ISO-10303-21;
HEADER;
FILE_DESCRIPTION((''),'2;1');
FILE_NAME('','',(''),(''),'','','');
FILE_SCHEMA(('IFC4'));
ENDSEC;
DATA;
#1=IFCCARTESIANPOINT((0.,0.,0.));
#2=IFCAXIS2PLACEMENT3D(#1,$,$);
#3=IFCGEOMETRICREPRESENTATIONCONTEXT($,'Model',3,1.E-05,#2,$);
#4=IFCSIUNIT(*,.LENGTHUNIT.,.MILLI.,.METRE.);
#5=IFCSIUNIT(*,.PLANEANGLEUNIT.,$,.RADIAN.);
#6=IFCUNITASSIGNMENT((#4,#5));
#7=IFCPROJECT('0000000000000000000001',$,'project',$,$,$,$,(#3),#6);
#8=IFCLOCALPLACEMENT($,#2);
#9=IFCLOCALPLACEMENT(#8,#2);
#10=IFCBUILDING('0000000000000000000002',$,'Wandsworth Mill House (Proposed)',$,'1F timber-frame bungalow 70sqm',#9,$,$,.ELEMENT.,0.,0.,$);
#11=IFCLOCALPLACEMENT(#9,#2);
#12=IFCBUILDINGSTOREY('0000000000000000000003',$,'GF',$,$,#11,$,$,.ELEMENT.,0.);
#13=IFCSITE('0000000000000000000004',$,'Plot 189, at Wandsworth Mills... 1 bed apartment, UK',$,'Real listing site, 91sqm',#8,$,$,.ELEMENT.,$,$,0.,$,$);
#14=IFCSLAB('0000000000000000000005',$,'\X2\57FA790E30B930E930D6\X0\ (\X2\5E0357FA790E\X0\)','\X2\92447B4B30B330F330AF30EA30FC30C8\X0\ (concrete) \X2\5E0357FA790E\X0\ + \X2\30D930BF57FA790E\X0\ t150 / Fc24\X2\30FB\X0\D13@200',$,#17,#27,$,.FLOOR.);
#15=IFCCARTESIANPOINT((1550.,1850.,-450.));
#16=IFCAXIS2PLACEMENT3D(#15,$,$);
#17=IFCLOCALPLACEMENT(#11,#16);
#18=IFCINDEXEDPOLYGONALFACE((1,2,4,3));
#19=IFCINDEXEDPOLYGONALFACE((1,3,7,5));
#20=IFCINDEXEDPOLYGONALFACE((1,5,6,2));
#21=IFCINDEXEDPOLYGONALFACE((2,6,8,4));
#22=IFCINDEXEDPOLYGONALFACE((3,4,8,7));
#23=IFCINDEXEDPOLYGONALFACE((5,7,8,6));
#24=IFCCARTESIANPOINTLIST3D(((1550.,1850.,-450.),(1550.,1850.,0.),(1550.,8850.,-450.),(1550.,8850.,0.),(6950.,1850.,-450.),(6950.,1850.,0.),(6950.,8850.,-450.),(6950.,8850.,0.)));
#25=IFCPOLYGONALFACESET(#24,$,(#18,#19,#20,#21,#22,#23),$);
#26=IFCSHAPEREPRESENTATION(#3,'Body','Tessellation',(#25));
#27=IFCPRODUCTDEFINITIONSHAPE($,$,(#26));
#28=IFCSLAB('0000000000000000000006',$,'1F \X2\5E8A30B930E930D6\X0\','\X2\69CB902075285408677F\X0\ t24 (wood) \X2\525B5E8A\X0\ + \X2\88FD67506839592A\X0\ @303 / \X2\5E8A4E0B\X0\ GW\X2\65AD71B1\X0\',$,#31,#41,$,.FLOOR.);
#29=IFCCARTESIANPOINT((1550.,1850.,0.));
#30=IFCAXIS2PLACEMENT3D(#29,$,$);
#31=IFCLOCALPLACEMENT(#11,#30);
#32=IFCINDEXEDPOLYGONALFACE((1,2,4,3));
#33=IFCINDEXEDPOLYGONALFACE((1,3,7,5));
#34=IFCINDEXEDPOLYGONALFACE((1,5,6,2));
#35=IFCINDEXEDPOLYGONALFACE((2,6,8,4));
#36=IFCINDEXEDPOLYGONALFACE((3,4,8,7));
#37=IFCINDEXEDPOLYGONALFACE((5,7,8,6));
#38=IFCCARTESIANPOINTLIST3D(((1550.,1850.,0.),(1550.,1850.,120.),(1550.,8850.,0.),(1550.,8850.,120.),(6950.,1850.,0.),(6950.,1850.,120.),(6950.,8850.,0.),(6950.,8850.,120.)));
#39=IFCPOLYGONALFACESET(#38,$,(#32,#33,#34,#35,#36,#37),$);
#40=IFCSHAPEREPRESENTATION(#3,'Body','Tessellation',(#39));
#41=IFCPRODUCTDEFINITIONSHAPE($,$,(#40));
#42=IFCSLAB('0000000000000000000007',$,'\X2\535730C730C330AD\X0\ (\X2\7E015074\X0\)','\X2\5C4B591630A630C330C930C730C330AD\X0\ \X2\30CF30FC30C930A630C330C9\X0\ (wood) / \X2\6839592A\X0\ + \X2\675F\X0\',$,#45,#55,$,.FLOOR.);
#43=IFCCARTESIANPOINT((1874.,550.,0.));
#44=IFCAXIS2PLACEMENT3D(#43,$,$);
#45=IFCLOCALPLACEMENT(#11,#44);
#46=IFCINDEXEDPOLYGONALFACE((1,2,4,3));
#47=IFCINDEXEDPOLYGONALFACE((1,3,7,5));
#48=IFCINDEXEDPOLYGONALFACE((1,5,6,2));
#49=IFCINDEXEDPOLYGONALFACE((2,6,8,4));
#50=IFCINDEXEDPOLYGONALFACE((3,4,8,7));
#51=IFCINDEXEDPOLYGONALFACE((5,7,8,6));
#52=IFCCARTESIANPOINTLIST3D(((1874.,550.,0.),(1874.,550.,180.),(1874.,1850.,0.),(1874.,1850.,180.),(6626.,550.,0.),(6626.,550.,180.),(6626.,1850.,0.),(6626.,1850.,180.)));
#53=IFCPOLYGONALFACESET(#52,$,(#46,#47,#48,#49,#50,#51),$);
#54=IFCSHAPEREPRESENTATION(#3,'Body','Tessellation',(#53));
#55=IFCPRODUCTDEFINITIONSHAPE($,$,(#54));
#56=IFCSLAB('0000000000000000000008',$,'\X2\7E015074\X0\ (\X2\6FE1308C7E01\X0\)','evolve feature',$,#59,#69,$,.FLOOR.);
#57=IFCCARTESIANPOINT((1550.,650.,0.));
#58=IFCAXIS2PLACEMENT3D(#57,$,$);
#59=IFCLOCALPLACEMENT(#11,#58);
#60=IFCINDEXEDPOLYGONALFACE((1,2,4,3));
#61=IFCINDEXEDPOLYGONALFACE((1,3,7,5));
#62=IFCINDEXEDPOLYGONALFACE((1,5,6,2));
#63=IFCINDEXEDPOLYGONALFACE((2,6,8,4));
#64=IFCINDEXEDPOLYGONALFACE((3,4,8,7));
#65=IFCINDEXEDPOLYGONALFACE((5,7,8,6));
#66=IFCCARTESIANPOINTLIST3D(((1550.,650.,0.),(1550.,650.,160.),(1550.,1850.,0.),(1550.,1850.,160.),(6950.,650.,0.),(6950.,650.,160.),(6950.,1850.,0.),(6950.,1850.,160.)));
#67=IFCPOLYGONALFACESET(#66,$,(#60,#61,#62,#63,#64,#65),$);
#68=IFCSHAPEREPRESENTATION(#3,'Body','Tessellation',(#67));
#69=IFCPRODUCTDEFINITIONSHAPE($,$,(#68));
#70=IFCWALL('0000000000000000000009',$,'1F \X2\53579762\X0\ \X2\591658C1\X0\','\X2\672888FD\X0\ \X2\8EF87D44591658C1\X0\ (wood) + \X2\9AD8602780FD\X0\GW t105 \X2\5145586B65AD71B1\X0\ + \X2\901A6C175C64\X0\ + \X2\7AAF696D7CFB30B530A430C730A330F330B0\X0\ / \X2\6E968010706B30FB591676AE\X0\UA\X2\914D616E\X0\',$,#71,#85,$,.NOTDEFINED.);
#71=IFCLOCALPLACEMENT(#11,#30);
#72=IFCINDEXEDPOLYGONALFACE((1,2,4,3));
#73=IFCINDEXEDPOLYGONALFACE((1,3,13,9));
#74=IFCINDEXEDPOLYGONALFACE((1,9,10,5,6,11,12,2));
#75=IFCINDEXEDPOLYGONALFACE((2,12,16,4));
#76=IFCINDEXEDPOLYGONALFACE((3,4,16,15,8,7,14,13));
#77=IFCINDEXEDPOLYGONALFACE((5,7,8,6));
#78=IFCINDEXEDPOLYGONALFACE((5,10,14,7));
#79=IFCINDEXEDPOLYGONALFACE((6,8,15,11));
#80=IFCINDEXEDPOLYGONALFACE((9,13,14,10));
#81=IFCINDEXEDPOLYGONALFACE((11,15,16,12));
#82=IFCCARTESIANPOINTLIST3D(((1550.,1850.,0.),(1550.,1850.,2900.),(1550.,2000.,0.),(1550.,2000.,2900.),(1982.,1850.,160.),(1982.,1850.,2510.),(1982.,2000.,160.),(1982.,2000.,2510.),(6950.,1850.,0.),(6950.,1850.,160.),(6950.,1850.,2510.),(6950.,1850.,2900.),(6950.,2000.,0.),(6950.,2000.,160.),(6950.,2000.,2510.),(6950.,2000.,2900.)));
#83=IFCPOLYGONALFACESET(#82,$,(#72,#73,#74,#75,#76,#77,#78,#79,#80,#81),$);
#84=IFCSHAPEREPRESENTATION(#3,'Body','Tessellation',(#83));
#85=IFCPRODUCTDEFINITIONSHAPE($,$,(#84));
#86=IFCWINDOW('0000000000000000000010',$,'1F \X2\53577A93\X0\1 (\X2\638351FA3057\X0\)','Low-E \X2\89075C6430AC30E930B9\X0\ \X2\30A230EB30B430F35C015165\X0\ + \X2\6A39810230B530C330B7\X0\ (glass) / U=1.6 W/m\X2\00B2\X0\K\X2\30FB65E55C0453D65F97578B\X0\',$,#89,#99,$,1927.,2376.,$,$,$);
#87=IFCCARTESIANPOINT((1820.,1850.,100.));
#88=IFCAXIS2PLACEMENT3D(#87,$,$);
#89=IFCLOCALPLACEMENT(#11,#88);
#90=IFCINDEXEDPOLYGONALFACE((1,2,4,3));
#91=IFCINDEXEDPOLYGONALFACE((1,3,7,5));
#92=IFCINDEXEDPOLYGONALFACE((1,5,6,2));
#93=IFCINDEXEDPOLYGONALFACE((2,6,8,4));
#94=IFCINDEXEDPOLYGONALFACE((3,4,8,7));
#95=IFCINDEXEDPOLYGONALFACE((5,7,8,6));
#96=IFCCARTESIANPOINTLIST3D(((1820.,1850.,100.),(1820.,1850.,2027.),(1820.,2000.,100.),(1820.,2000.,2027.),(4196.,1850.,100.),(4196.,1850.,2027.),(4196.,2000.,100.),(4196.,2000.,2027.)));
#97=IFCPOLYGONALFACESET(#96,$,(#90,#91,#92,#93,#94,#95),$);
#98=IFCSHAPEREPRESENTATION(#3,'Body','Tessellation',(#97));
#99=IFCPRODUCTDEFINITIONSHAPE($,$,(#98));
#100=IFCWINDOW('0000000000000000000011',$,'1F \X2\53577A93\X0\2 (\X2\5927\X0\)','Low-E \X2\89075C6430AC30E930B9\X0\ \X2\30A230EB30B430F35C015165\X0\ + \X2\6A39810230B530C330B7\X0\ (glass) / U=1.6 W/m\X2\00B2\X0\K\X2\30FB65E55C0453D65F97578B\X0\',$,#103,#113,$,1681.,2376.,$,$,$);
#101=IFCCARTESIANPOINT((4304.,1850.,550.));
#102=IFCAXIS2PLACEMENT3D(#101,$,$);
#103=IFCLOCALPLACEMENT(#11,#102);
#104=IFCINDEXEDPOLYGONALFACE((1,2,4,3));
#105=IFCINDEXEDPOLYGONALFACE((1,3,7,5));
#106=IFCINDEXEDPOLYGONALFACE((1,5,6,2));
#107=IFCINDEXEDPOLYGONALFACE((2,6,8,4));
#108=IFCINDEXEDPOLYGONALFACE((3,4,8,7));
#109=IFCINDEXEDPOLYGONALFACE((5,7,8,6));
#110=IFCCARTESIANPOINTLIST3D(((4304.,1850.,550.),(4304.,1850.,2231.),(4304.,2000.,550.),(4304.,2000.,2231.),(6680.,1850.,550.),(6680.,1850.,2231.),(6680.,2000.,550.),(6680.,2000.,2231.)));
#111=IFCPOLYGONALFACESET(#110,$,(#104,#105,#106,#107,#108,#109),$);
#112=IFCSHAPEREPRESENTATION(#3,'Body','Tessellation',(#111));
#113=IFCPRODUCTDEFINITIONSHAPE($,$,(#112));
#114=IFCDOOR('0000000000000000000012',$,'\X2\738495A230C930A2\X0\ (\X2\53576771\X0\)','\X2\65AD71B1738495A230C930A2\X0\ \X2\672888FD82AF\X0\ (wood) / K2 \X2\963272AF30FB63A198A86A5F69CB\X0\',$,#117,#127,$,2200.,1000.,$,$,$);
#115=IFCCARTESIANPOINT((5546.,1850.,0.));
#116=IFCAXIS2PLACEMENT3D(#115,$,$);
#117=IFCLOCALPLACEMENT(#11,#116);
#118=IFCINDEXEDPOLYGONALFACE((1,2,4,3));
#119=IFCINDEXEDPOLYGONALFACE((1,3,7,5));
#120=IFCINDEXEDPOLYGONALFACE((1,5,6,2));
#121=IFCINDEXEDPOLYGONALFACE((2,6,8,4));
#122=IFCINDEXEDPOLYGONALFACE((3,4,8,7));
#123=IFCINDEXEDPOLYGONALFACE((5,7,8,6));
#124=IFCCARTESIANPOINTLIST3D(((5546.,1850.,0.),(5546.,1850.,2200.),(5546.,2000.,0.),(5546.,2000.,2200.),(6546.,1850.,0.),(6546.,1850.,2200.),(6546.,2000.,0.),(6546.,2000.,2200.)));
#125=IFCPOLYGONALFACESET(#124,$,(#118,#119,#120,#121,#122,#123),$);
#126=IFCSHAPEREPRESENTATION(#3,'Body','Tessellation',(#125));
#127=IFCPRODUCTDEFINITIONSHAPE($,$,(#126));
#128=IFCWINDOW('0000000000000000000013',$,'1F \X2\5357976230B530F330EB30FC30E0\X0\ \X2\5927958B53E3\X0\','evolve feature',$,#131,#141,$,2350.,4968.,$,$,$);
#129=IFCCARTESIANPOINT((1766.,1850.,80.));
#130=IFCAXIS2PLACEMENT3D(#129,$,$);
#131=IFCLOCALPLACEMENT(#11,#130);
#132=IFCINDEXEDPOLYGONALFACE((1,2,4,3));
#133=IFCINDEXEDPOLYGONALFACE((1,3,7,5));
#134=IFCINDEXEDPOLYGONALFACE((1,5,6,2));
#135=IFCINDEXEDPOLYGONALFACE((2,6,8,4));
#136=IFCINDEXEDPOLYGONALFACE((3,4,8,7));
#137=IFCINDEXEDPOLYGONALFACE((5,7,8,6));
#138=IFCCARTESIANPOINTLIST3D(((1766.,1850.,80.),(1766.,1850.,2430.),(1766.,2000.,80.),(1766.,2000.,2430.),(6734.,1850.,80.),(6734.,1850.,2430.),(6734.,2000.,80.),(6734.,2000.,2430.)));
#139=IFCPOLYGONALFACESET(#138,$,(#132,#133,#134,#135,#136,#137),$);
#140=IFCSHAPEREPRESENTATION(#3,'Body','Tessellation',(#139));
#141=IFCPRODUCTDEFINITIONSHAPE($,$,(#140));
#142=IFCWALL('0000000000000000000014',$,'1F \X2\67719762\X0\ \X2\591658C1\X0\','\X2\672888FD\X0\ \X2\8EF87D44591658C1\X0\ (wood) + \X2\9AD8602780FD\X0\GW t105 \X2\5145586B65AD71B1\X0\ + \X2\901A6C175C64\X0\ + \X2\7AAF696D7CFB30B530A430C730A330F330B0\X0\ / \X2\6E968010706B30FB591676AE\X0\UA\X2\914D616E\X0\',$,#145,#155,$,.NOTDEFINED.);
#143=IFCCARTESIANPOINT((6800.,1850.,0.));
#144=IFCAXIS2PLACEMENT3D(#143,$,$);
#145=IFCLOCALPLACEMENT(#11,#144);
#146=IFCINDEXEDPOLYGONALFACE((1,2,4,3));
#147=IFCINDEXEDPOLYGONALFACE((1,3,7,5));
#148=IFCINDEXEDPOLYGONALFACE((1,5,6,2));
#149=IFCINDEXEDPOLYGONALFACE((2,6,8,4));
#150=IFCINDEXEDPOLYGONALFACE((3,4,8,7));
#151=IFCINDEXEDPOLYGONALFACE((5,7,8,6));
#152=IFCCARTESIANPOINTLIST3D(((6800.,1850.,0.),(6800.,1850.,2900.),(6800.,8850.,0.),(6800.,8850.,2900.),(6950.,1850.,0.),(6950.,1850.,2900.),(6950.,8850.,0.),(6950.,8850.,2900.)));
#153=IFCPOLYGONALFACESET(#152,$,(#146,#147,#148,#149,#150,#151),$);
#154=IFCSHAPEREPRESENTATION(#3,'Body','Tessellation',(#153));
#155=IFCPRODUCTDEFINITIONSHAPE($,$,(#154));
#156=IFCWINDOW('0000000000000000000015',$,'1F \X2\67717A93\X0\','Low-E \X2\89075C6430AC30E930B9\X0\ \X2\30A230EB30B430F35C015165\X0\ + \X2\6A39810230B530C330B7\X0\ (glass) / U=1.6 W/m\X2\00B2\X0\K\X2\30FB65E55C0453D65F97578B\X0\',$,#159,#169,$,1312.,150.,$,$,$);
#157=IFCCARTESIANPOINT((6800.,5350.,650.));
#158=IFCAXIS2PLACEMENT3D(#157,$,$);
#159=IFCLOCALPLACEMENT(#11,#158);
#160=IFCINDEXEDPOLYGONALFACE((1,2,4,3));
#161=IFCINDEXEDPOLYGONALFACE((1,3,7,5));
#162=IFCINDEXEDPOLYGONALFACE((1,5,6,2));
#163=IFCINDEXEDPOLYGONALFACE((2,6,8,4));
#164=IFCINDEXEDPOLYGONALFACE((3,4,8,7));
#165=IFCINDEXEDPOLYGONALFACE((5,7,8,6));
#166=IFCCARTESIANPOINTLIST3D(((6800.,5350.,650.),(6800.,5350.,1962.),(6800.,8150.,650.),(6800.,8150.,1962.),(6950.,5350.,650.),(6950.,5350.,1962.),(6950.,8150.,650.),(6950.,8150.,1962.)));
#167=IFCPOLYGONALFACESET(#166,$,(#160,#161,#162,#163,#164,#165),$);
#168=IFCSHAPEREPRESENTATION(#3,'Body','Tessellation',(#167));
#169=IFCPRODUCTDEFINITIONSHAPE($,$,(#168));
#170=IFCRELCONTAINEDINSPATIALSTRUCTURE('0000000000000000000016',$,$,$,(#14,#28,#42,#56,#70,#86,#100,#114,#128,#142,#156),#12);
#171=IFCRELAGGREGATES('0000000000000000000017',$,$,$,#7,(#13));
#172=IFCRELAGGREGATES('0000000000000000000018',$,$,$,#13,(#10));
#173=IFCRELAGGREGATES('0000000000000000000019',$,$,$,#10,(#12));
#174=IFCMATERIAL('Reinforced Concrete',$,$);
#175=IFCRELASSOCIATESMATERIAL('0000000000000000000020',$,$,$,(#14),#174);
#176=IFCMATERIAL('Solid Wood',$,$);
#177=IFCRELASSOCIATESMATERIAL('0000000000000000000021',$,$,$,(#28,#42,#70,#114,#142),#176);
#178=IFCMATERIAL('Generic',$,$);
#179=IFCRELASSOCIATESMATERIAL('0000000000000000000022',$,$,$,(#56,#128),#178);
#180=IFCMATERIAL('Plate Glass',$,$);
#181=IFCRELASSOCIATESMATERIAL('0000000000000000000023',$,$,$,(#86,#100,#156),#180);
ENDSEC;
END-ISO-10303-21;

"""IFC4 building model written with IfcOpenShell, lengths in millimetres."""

from ifc_helpers import new_model, si_unit, frame, frame_2d, origin, place, context, project, spatial, rectangle, extrude, material, element, fill, save


model = new_model("IFC4")

# Units and contexts
model_context = context("Model", 3, precision=1e-05, world=origin())
ifc_project = project(units=[si_unit("LENGTHUNIT", "METRE", prefix="MILLI"), si_unit("PLANEANGLEUNIT", "RADIAN")], contexts=[model_context])

# Site, building, storey
site_placement = place(None, origin())
site = spatial("IfcSite", under=ifc_project, at=site_placement, Name="Plot 189, at Wandsworth Mills... 1 bed apartment, UK", ObjectType="Real listing site, 91sqm", CompositionType="ELEMENT", RefElevation=0.0)
building_placement = place(site_placement, origin())
building = spatial("IfcBuilding", under=site, at=building_placement, Name="Wandsworth Mill House (Proposed)", ObjectType="1F timber-frame bungalow 70sqm", CompositionType="ELEMENT", ElevationOfRefHeight=0.0, ElevationOfTerrain=0.0)
storey_placement = place(building_placement, origin())
storey = spatial("IfcBuildingStorey", under=building, at=storey_placement, Name="GF", CompositionType="ELEMENT", Elevation=0.0)

# Slabs
ifc_material_1 = material(Name="Reinforced Concrete")
slab_1_placement = place(storey_placement, frame((1550.0, 1850.0, -450.0)))
element("IfcSlab", 1, at=slab_1_placement, inside=storey, material=ifc_material_1, Name="基礎スラブ (布基礎)", Description="鉄筋コンクリート (concrete) 布基礎 + ベタ基礎 t150 / Fc24・D13@200", PredefinedType="FLOOR", context=model_context, shape_type="SweptSolid", body=[
    extrude(rectangle(XDim=5400.0, YDim=7000.0, at=frame_2d((2700.0, 3500.0))), frame((1550.0, 1850.0, -450.0)), (0.0, 0.0, 1.0), 450.0),
])
ifc_material_2 = material(Name="Solid Wood")
slab_2_placement = place(storey_placement, frame((1550.0, 1850.0, 0.0)))
element("IfcSlab", 2, at=slab_2_placement, inside=storey, material=ifc_material_2, Name="1F 床スラブ", Description="構造用合板 t24 (wood) 剛床 + 製材根太 @303 / 床下 GW断熱", PredefinedType="FLOOR", context=model_context, shape_type="SweptSolid", body=[
    extrude(rectangle(XDim=5400.0, YDim=7000.0, at=frame_2d((2700.0, 3500.0))), frame((1550.0, 1850.0, 0.0)), (0.0, 0.0, 1.0), 120.0),
])
slab_3_placement = place(storey_placement, frame((1874.0, 550.0, 0.0)))
element("IfcSlab", 3, at=slab_3_placement, inside=storey, material=ifc_material_2, Name="南デッキ (縁側)", Description="屋外ウッドデッキ ハードウッド (wood) / 根太 + 束", PredefinedType="FLOOR", context=model_context, shape_type="SweptSolid", body=[
    extrude(rectangle(XDim=4752.0, YDim=1300.0, at=frame_2d((2376.0, 650.0))), frame((1874.0, 550.0, 0.0)), (0.0, 0.0, 1.0), 180.0),
])
ifc_material_3 = material(Name="Generic")
slab_4_placement = place(storey_placement, frame((1550.0, 650.0, 0.0)))
element("IfcSlab", 4, at=slab_4_placement, inside=storey, material=ifc_material_3, Name="縁側 (濡れ縁)", Description="evolve feature", PredefinedType="FLOOR", context=model_context, shape_type="SweptSolid", body=[
    extrude(rectangle(XDim=5400.0, YDim=1200.0, at=frame_2d((2700.0, 600.0))), frame((1550.0, 650.0, 0.0)), (0.0, 0.0, 1.0), 160.0),
])

# Wall, openings, windows, door
wall_1_placement = place(storey_placement, frame((1550.0, 1850.0, 0.0)))
wall_1 = element("IfcWall", 5, at=wall_1_placement, inside=storey, material=ifc_material_2, Name="1F 南面 外壁", Description="木製 軸組外壁 (wood) + 高性能GW t105 充填断熱 + 通気層 + 窯業系サイディング / 準耐火・外皮UA配慮", PredefinedType="NOTDEFINED", context=model_context, shape_type="SweptSolid", body=[
    extrude(rectangle(XDim=5400.0, YDim=150.0, at=frame_2d((2700.0, 75.0))), frame((1550.0, 1850.0, 0.0)), (0.0, 0.0, 1.0), 2900.0),
])
opening_1_placement = place(storey_placement, frame((1820.0, 1850.0, 100.0)))
opening_1 = element("IfcOpeningElement", 6, at=opening_1_placement, cuts=wall_1, PredefinedType="NOTDEFINED", context=model_context, shape_type="SweptSolid", body=[
    extrude(rectangle(XDim=2376.0, YDim=150.0, at=frame_2d((1188.0, 75.0))), frame((1820.0, 1850.0, 100.0)), (0.0, 0.0, 1.0), 1927.0),
])
opening_2_placement = place(storey_placement, frame((4304.0, 1850.0, 550.0)))
opening_2 = element("IfcOpeningElement", 7, at=opening_2_placement, cuts=wall_1, PredefinedType="NOTDEFINED", context=model_context, shape_type="SweptSolid", body=[
    extrude(rectangle(XDim=2376.0, YDim=150.0, at=frame_2d((1188.0, 75.0))), frame((4304.0, 1850.0, 550.0)), (0.0, 0.0, 1.0), 1681.0),
])
opening_3_placement = place(storey_placement, frame((5546.0, 1850.0, 0.0)))
opening_3 = element("IfcOpeningElement", 8, at=opening_3_placement, cuts=wall_1, PredefinedType="NOTDEFINED", context=model_context, shape_type="SweptSolid", body=[
    extrude(rectangle(XDim=1000.0, YDim=150.0, at=frame_2d((500.0, 75.0))), frame((5546.0, 1850.0, 0.0)), (0.0, 0.0, 1.0), 2200.0),
])
opening_4_placement = place(storey_placement, frame((1766.0, 1850.0, 80.0)))
opening_4 = element("IfcOpeningElement", 9, at=opening_4_placement, cuts=wall_1, PredefinedType="NOTDEFINED", context=model_context, shape_type="SweptSolid", body=[
    extrude(rectangle(XDim=4968.0, YDim=150.0, at=frame_2d((2484.0, 75.0))), frame((1766.0, 1850.0, 80.0)), (0.0, 0.0, 1.0), 2350.0),
])
ifc_material_4 = material(Name="Plate Glass")
window_1_placement = place(storey_placement, frame((1820.0, 1850.0, 100.0)))
window_1 = element("IfcWindow", 10, at=window_1_placement, inside=storey, material=ifc_material_4, Name="1F 南窓1 (掃出し)", Description="Low-E 複層ガラス アルゴン封入 + 樹脂サッシ (glass) / U=1.6 W/m²K・日射取得型", OverallHeight=1927.0, OverallWidth=2376.0, context=model_context, shape_type="SweptSolid", body=[
    extrude(rectangle(XDim=2376.0, YDim=150.0, at=frame_2d((1188.0, 75.0))), frame((1820.0, 1850.0, 100.0)), (0.0, 0.0, 1.0), 1927.0),
])
fill(opening_1, window_1)
window_2_placement = place(storey_placement, frame((4304.0, 1850.0, 550.0)))
window_2 = element("IfcWindow", 11, at=window_2_placement, inside=storey, material=ifc_material_4, Name="1F 南窓2 (大)", Description="Low-E 複層ガラス アルゴン封入 + 樹脂サッシ (glass) / U=1.6 W/m²K・日射取得型", OverallHeight=1681.0, OverallWidth=2376.0, context=model_context, shape_type="SweptSolid", body=[
    extrude(rectangle(XDim=2376.0, YDim=150.0, at=frame_2d((1188.0, 75.0))), frame((4304.0, 1850.0, 550.0)), (0.0, 0.0, 1.0), 1681.0),
])
fill(opening_2, window_2)
door_placement = place(storey_placement, frame((5546.0, 1850.0, 0.0)))
door = element("IfcDoor", 12, at=door_placement, inside=storey, material=ifc_material_2, Name="玄関ドア (南東)", Description="断熱玄関ドア 木製芯 (wood) / K2 防犯・採風機構", OverallHeight=2200.0, OverallWidth=1000.0, context=model_context, shape_type="SweptSolid", body=[
    extrude(rectangle(XDim=1000.0, YDim=150.0, at=frame_2d((500.0, 75.0))), frame((5546.0, 1850.0, 0.0)), (0.0, 0.0, 1.0), 2200.0),
])
fill(opening_3, door)
window_3_placement = place(storey_placement, frame((1766.0, 1850.0, 80.0)))
window_3 = element("IfcWindow", 13, at=window_3_placement, inside=storey, material=ifc_material_3, Name="1F 南面サンルーム 大開口", Description="evolve feature", OverallHeight=2350.0, OverallWidth=4968.0, context=model_context, shape_type="SweptSolid", body=[
    extrude(rectangle(XDim=4968.0, YDim=150.0, at=frame_2d((2484.0, 75.0))), frame((1766.0, 1850.0, 80.0)), (0.0, 0.0, 1.0), 2350.0),
])
fill(opening_4, window_3)

# Wall, opening, window
wall_2_placement = place(storey_placement, frame((6800.0, 1850.0, 0.0)))
wall_2 = element("IfcWall", 14, at=wall_2_placement, inside=storey, material=ifc_material_2, Name="1F 東面 外壁", Description="木製 軸組外壁 (wood) + 高性能GW t105 充填断熱 + 通気層 + 窯業系サイディング / 準耐火・外皮UA配慮", PredefinedType="NOTDEFINED", context=model_context, shape_type="SweptSolid", body=[
    extrude(rectangle(XDim=150.0, YDim=7000.0, at=frame_2d((75.0, 3500.0))), frame((6800.0, 1850.0, 0.0)), (0.0, 0.0, 1.0), 2900.0),
])
opening_5_placement = place(storey_placement, frame((6800.0, 5350.0, 650.0)))
opening_5 = element("IfcOpeningElement", 15, at=opening_5_placement, cuts=wall_2, PredefinedType="NOTDEFINED", context=model_context, shape_type="SweptSolid", body=[
    extrude(rectangle(XDim=150.0, YDim=2800.0, at=frame_2d((75.0, 1400.0))), frame((6800.0, 5350.0, 650.0)), (0.0, 0.0, 1.0), 1312.0),
])
window_4_placement = place(storey_placement, frame((6800.0, 5350.0, 650.0)))
window_4 = element("IfcWindow", 16, at=window_4_placement, inside=storey, material=ifc_material_4, Name="1F 東窓", Description="Low-E 複層ガラス アルゴン封入 + 樹脂サッシ (glass) / U=1.6 W/m²K・日射取得型", OverallHeight=1312.0, OverallWidth=150.0, context=model_context, shape_type="SweptSolid", body=[
    extrude(rectangle(XDim=150.0, YDim=2800.0, at=frame_2d((75.0, 1400.0))), frame((6800.0, 5350.0, 650.0)), (0.0, 0.0, 1.0), 1312.0),
])
fill(opening_5, window_4)

save(model, "model.ifc")
